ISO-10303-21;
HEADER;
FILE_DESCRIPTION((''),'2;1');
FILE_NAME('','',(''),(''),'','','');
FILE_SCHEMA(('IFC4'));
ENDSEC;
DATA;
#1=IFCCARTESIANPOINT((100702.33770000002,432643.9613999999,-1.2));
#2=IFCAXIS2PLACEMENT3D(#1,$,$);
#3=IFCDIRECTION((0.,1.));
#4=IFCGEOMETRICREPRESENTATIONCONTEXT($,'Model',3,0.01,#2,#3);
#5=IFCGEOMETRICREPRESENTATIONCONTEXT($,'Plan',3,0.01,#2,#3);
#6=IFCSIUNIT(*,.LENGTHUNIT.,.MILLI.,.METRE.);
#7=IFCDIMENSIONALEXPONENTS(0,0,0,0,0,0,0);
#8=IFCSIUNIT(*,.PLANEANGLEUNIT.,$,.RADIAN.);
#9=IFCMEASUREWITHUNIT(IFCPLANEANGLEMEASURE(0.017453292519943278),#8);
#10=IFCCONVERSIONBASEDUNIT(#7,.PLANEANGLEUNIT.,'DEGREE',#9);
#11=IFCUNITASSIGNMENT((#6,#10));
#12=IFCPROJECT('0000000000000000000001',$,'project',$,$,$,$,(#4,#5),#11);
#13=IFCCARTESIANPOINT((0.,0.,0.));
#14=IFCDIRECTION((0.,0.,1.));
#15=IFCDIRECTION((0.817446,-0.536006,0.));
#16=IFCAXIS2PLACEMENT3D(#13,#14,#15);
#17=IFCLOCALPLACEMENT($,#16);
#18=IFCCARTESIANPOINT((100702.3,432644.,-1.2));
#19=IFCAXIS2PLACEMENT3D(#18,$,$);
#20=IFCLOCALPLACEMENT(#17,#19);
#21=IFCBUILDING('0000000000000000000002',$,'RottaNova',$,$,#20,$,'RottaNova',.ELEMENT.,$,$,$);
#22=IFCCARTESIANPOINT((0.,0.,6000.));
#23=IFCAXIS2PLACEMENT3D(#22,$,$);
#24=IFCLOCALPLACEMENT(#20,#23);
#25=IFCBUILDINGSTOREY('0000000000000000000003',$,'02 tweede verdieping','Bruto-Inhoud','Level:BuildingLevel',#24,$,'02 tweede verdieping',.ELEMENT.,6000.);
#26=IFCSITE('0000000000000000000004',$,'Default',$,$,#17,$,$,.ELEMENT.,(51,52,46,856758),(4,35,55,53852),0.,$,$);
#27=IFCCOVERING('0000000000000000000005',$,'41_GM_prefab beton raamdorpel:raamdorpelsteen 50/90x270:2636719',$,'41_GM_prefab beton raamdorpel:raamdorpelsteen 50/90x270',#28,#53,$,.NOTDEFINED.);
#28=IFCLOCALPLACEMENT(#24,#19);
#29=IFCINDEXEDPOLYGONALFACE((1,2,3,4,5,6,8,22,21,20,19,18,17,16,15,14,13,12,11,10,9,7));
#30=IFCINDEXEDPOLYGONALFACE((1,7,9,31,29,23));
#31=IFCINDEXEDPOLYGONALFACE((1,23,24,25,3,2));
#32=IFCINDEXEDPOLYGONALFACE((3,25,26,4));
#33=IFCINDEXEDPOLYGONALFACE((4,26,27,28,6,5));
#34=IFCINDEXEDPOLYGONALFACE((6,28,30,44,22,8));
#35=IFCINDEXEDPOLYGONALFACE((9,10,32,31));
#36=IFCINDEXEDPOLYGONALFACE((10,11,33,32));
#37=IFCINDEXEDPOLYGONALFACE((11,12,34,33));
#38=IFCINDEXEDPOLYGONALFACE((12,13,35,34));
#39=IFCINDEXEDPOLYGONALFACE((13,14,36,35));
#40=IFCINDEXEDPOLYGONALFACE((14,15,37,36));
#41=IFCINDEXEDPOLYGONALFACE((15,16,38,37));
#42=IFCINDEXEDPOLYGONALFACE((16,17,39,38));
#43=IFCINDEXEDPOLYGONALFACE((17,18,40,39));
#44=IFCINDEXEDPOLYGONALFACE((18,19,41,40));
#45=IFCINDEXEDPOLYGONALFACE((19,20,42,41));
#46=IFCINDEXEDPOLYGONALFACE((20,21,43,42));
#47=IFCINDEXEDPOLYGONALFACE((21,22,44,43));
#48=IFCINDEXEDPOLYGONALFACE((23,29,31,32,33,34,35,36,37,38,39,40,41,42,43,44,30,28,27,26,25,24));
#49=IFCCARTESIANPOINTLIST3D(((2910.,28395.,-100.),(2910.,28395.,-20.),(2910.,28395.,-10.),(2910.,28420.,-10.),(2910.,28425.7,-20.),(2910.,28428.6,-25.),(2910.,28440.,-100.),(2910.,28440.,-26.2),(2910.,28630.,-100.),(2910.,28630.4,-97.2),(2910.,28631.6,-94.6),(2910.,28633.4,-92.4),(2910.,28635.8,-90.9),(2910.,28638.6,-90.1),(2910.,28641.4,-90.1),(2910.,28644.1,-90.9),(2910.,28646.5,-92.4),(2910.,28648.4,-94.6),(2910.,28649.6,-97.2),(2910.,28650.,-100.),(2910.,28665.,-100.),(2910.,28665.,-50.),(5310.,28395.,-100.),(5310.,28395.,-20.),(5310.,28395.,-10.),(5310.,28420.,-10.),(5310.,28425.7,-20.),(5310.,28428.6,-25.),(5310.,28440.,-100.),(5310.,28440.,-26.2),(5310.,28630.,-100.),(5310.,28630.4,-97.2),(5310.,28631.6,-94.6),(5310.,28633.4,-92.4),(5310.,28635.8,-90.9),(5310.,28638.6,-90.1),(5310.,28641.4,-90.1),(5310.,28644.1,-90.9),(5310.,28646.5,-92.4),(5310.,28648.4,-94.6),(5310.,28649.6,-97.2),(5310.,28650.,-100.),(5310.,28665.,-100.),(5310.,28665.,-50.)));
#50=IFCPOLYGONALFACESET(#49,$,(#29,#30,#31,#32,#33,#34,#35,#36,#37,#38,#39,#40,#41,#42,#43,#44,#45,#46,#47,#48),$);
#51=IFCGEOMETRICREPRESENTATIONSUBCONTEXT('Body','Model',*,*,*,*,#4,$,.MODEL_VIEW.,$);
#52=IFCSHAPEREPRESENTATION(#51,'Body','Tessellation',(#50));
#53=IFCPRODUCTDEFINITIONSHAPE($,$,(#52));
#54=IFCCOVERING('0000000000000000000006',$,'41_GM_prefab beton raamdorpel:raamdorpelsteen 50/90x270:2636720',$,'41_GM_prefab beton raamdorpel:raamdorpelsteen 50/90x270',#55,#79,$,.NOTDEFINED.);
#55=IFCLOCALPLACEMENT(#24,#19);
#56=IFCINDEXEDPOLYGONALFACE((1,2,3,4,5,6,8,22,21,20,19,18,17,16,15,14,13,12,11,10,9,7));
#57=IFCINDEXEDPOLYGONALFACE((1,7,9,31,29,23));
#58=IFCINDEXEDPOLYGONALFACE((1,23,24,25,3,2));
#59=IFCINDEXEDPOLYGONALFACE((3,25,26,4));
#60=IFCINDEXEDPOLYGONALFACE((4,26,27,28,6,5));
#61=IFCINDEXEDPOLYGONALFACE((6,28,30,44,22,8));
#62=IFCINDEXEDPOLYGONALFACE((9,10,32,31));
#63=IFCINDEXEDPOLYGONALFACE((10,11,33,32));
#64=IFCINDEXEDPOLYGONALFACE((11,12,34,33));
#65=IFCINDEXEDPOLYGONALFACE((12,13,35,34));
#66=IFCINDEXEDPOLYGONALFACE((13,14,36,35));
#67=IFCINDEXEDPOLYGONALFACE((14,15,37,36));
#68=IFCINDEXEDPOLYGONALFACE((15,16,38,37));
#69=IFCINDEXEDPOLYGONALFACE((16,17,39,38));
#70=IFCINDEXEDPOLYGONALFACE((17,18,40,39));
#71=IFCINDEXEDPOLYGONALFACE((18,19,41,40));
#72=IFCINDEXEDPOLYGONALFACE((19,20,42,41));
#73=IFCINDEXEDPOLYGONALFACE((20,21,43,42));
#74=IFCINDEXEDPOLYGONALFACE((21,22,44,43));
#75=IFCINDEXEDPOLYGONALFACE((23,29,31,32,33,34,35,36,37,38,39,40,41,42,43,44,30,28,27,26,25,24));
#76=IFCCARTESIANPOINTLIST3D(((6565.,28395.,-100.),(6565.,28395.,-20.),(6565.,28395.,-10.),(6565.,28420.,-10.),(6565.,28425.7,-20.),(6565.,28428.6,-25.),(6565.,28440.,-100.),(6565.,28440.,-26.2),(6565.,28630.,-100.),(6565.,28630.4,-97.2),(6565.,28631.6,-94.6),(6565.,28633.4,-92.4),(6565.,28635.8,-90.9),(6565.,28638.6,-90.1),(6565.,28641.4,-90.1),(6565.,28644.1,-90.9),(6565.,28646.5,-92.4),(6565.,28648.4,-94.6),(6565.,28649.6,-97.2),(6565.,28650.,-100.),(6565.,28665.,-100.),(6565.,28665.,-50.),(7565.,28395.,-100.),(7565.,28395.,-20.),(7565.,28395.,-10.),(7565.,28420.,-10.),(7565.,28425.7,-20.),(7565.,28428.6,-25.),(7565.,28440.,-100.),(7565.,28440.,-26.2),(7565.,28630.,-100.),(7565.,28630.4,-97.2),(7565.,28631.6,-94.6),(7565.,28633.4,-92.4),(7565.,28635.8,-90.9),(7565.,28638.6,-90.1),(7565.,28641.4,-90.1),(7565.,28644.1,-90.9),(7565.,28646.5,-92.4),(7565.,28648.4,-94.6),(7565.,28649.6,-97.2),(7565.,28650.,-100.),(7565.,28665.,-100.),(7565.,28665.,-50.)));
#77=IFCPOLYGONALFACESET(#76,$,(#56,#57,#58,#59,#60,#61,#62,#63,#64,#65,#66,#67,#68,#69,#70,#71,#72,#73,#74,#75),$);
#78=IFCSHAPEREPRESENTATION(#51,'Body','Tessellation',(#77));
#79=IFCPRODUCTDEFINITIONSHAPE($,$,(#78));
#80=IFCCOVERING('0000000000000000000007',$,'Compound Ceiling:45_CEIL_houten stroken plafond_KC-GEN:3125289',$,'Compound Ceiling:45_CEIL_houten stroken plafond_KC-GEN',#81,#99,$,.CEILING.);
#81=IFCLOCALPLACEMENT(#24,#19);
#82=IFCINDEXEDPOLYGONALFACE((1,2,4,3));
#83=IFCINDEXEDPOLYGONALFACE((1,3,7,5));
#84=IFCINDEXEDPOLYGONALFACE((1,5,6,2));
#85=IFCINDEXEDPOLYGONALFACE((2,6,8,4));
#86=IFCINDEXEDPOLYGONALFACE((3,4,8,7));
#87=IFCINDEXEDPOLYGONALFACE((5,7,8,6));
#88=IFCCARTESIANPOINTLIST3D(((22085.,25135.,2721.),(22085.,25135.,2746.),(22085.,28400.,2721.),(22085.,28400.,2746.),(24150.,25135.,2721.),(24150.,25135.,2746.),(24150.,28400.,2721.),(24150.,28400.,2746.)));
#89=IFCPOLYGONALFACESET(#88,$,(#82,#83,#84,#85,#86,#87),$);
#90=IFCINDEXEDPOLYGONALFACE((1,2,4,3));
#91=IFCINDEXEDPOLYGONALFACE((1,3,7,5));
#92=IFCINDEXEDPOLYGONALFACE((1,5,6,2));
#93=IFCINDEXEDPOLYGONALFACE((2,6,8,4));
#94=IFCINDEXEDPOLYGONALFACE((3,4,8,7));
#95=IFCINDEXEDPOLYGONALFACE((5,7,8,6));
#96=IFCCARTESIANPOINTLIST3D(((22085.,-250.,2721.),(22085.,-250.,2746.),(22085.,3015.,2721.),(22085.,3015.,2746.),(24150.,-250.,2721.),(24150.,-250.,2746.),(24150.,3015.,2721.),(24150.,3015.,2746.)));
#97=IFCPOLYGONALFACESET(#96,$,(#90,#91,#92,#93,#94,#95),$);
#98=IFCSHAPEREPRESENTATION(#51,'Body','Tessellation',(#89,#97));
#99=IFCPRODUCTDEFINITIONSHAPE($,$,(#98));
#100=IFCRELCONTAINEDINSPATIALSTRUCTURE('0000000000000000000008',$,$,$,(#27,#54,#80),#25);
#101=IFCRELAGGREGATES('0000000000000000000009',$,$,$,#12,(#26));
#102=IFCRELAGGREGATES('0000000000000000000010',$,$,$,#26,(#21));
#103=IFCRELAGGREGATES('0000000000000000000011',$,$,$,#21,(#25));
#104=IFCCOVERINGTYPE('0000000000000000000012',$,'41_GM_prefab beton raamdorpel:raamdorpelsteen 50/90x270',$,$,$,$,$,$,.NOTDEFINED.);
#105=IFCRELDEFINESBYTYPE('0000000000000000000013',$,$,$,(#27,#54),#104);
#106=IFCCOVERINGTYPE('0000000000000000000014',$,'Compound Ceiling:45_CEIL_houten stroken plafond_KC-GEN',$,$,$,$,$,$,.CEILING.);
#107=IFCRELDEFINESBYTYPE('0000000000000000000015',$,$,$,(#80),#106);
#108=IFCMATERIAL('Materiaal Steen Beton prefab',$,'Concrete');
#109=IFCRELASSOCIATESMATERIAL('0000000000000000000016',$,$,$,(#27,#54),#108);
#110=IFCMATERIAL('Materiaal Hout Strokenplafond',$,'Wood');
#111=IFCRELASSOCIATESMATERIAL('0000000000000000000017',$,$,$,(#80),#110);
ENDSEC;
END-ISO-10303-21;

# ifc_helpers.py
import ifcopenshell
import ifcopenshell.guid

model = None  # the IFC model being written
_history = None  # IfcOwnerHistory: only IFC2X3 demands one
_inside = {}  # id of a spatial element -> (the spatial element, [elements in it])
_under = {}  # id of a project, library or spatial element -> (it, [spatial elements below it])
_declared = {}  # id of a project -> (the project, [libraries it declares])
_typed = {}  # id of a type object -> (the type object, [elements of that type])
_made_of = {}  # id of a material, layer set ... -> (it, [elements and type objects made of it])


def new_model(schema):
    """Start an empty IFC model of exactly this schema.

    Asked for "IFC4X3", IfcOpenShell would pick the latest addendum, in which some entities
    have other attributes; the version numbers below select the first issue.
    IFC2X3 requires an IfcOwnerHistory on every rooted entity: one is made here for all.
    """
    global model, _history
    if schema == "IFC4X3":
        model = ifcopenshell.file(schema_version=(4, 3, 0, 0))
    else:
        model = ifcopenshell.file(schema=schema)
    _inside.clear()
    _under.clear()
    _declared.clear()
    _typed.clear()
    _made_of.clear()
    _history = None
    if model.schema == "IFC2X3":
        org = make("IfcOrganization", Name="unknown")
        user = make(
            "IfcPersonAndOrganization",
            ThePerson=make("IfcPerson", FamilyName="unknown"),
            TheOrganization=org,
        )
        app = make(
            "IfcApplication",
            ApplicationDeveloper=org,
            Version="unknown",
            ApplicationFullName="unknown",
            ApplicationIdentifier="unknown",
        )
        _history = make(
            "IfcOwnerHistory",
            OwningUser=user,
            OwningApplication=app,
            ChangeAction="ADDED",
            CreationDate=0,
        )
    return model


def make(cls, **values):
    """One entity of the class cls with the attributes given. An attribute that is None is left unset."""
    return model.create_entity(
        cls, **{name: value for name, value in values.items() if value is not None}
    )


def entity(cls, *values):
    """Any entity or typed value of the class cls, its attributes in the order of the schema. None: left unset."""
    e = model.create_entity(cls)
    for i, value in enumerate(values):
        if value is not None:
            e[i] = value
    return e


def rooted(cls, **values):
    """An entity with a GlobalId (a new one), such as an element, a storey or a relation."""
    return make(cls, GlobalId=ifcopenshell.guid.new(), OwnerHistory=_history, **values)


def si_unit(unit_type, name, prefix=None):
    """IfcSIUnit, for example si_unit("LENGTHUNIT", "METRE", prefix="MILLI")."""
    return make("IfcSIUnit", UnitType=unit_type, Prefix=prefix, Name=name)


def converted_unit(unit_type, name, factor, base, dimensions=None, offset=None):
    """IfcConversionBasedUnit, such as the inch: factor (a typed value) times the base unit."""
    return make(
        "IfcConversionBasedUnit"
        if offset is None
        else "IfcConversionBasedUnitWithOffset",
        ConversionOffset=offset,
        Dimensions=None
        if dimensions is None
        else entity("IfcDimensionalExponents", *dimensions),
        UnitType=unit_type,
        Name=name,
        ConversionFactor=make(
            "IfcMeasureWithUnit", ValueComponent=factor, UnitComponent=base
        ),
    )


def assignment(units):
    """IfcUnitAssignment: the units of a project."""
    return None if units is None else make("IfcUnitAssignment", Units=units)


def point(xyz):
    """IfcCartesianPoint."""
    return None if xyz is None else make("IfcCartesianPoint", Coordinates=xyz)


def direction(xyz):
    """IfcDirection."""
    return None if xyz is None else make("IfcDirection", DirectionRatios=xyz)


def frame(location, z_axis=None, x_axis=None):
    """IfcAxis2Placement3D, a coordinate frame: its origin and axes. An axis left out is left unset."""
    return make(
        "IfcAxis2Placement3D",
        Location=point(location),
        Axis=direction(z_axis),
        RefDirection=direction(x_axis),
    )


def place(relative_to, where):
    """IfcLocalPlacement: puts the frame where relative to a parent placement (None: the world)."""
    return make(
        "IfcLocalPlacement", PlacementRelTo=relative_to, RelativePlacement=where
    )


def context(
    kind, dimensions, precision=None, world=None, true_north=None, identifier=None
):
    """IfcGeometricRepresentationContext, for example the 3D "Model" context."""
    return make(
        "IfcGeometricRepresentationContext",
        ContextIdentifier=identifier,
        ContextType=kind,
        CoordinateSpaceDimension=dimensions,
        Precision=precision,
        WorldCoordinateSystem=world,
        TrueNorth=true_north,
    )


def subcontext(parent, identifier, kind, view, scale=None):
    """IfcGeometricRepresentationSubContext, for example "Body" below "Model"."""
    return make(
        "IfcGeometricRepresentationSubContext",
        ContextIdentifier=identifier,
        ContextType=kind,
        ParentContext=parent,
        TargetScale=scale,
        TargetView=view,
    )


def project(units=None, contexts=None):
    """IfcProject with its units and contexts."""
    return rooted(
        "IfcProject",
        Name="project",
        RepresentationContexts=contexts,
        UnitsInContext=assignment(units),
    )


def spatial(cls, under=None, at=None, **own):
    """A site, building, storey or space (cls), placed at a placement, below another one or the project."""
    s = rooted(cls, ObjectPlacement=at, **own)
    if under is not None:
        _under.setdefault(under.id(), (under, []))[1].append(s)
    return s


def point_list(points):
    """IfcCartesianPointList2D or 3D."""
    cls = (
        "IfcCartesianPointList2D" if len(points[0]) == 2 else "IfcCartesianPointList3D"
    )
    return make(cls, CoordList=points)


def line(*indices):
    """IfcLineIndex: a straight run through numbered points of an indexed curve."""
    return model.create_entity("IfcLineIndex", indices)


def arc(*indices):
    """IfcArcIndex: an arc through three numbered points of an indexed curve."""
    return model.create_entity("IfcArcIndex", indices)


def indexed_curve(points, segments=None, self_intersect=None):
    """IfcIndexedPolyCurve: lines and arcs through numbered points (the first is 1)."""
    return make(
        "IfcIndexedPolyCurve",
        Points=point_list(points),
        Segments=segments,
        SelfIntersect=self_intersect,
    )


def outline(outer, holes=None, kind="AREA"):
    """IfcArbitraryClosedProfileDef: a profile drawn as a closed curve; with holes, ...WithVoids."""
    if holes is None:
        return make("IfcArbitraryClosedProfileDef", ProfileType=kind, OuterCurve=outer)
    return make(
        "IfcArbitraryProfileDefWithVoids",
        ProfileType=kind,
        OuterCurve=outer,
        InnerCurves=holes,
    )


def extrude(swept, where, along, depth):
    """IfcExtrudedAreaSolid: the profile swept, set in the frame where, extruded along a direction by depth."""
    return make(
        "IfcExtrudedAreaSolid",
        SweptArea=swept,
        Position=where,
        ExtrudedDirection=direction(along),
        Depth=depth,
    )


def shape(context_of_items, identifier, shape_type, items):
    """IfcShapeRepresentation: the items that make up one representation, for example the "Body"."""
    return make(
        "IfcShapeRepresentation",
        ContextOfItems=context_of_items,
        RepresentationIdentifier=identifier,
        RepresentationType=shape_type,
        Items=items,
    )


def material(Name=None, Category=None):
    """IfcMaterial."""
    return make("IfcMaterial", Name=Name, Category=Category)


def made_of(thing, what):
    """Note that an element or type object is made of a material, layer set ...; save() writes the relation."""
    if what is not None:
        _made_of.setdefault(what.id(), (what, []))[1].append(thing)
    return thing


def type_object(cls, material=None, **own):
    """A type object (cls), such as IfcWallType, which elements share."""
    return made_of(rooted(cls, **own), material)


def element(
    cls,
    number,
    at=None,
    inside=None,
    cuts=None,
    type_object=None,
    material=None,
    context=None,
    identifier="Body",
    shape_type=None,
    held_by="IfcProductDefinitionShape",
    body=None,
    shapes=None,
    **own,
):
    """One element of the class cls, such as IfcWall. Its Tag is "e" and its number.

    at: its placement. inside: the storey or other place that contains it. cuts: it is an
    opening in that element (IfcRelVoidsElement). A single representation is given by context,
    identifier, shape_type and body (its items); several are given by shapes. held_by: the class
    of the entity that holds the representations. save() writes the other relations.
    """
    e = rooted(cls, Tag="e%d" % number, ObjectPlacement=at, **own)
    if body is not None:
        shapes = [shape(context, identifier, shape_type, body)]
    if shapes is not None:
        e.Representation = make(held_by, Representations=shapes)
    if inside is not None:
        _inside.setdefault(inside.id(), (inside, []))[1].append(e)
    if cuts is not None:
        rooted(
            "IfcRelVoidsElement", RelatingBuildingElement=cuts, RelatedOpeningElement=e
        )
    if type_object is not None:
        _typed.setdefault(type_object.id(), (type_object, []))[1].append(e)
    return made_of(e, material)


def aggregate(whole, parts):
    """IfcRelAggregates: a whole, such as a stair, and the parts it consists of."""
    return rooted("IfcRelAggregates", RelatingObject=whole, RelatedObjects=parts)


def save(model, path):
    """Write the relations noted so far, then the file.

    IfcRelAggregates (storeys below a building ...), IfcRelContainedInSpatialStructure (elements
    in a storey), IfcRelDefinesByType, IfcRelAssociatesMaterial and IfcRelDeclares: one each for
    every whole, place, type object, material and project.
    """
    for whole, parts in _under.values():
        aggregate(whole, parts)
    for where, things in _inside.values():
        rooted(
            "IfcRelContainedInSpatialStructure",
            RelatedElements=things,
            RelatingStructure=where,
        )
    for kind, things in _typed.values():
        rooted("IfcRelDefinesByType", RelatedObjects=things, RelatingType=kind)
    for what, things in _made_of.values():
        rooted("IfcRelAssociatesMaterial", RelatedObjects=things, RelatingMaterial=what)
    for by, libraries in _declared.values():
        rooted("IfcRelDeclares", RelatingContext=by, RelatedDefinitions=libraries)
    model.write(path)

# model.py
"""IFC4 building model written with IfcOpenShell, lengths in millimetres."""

from ifc_helpers import new_model, entity, si_unit, converted_unit, direction, frame, place, context, subcontext, project, spatial, line, arc, indexed_curve, outline, extrude, material, type_object, element, save


model = new_model("IFC4")

# Units and contexts
model_context = context("Model", 3, precision=0.01, world=frame((100702.33770000002, 432643.9613999999, -1.2)), true_north=direction((0.0, 1.0)))
plan_context = context("Plan", 3, precision=0.01, world=frame((100702.33770000002, 432643.9613999999, -1.2)), true_north=direction((0.0, 1.0)))
body_context = subcontext(model_context, "Body", "Model", "MODEL_VIEW")
ifc_project = project(units=[si_unit("LENGTHUNIT", "METRE", prefix="MILLI"), converted_unit("PLANEANGLEUNIT", "DEGREE", entity("IfcPlaneAngleMeasure", 0.017453292519943278), si_unit("PLANEANGLEUNIT", "RADIAN"), dimensions=[0, 0, 0, 0, 0, 0, 0])], contexts=[model_context, plan_context])

# Site, building, storey
site_placement = place(None, frame((0.0, 0.0, 0.0), z_axis=(0.0, 0.0, 1.0), x_axis=(0.817446, -0.536006, 0.0)))
site = spatial("IfcSite", under=ifc_project, at=site_placement, Name="Default", CompositionType="ELEMENT", RefLatitude=(51, 52, 46, 856758), RefLongitude=(4, 35, 55, 53852), RefElevation=0.0)
building_placement = place(site_placement, frame((100702.3, 432644.0, -1.2)))
building = spatial("IfcBuilding", under=site, at=building_placement, Name="RottaNova", LongName="RottaNova", CompositionType="ELEMENT")
storey_placement = place(building_placement, frame((0.0, 0.0, 6000.0)))
storey = spatial("IfcBuildingStorey", under=building, at=storey_placement, Name="02 tweede verdieping", Description="Bruto-Inhoud", ObjectType="Level:BuildingLevel", LongName="02 tweede verdieping", CompositionType="ELEMENT", Elevation=6000.0)

# Shared definitions
ifc_material_1 = material(Name="Materiaal Steen Beton prefab", Category="Concrete")

# Coverings
covering_type_1 = type_object("IfcCoveringType", Name="41_GM_prefab beton raamdorpel:raamdorpelsteen 50/90x270", PredefinedType="NOTDEFINED")
covering_1_placement = place(storey_placement, frame((100702.3, 432644.0, -1.2)))
element("IfcCovering", 1, at=covering_1_placement, inside=storey, type_object=covering_type_1, material=ifc_material_1, Name="41_GM_prefab beton raamdorpel:raamdorpelsteen 50/90x270:2636719", ObjectType="41_GM_prefab beton raamdorpel:raamdorpelsteen 50/90x270", PredefinedType="NOTDEFINED", context=body_context, shape_type="SweptSolid", body=[
    extrude(outline(indexed_curve([(75.8, -45.1), (100.8, -45.1), (100.8, -35.1), (100.8, 44.9), (55.8, 44.9), (-134.2, 44.9), (-144.2, 34.9), (-154.2, 44.9), (-169.2, 44.9), (-169.2, -5.1), (55.8, -28.9), (67.1, -30.1), (70.0, -35.1)], segments=[line(1, 2, 3, 4, 5, 6), arc(6, 7, 8), line(8, 9, 10, 11, 12, 13, 1)], self_intersect=False)), frame((2910.0, 28495.8, -55.1), z_axis=(1.0, 0.0, 0.0), x_axis=(0.0, -1.0, 0.0)), (0.0, 0.0, 1.0), 2400.0),
])
covering_2_placement = place(storey_placement, frame((100702.3, 432644.0, -1.2)))
element("IfcCovering", 2, at=covering_2_placement, inside=storey, type_object=covering_type_1, material=ifc_material_1, Name="41_GM_prefab beton raamdorpel:raamdorpelsteen 50/90x270:2636720", ObjectType="41_GM_prefab beton raamdorpel:raamdorpelsteen 50/90x270", PredefinedType="NOTDEFINED", context=body_context, shape_type="SweptSolid", body=[
    extrude(outline(indexed_curve([(75.8, -45.1), (100.8, -45.1), (100.8, -35.1), (100.8, 44.9), (55.8, 44.9), (-134.2, 44.9), (-144.2, 34.9), (-154.2, 44.9), (-169.2, 44.9), (-169.2, -5.1), (55.8, -28.9), (67.1, -30.1), (70.0, -35.1)], segments=[line(1, 2, 3, 4, 5, 6), arc(6, 7, 8), line(8, 9, 10, 11, 12, 13, 1)], self_intersect=False)), frame((6565.0, 28495.8, -55.1), z_axis=(1.0, 0.0, 0.0), x_axis=(0.0, -1.0, 0.0)), (0.0, 0.0, 1.0), 1000.0),
])
ifc_material_2 = material(Name="Materiaal Hout Strokenplafond", Category="Wood")
covering_type_2 = type_object("IfcCoveringType", Name="Compound Ceiling:45_CEIL_houten stroken plafond_KC-GEN", PredefinedType="CEILING")
covering_3_placement = place(storey_placement, frame((100702.3, 432644.0, -1.2)))
element("IfcCovering", 3, at=covering_3_placement, inside=storey, type_object=covering_type_2, material=ifc_material_2, Name="Compound Ceiling:45_CEIL_houten stroken plafond_KC-GEN:3125289", ObjectType="Compound Ceiling:45_CEIL_houten stroken plafond_KC-GEN", PredefinedType="CEILING", context=body_context, shape_type="SweptSolid", body=[
    extrude(outline(indexed_curve([(-1032.5, -1632.5), (1032.5, -1632.5), (1032.5, 1632.5), (-1032.5, 1632.5), (-1032.5, -1632.5)], self_intersect=False)), frame((23117.5, 26767.5, 2721.0), z_axis=(0.0, 0.0, 1.0), x_axis=(-1.0, 0.0, 0.0)), (0.0, 0.0, 1.0), 25.0),
    extrude(outline(indexed_curve([(-1032.5, -1632.5), (1032.5, -1632.5), (1032.5, 1632.5), (-1032.5, 1632.5), (-1032.5, -1632.5)], self_intersect=False)), frame((23117.5, 1382.5, 2721.0), z_axis=(0.0, 0.0, 1.0), x_axis=(-1.0, 0.0, 0.0)), (0.0, 0.0, 1.0), 25.0),
])

save(model, "model.ifc")
